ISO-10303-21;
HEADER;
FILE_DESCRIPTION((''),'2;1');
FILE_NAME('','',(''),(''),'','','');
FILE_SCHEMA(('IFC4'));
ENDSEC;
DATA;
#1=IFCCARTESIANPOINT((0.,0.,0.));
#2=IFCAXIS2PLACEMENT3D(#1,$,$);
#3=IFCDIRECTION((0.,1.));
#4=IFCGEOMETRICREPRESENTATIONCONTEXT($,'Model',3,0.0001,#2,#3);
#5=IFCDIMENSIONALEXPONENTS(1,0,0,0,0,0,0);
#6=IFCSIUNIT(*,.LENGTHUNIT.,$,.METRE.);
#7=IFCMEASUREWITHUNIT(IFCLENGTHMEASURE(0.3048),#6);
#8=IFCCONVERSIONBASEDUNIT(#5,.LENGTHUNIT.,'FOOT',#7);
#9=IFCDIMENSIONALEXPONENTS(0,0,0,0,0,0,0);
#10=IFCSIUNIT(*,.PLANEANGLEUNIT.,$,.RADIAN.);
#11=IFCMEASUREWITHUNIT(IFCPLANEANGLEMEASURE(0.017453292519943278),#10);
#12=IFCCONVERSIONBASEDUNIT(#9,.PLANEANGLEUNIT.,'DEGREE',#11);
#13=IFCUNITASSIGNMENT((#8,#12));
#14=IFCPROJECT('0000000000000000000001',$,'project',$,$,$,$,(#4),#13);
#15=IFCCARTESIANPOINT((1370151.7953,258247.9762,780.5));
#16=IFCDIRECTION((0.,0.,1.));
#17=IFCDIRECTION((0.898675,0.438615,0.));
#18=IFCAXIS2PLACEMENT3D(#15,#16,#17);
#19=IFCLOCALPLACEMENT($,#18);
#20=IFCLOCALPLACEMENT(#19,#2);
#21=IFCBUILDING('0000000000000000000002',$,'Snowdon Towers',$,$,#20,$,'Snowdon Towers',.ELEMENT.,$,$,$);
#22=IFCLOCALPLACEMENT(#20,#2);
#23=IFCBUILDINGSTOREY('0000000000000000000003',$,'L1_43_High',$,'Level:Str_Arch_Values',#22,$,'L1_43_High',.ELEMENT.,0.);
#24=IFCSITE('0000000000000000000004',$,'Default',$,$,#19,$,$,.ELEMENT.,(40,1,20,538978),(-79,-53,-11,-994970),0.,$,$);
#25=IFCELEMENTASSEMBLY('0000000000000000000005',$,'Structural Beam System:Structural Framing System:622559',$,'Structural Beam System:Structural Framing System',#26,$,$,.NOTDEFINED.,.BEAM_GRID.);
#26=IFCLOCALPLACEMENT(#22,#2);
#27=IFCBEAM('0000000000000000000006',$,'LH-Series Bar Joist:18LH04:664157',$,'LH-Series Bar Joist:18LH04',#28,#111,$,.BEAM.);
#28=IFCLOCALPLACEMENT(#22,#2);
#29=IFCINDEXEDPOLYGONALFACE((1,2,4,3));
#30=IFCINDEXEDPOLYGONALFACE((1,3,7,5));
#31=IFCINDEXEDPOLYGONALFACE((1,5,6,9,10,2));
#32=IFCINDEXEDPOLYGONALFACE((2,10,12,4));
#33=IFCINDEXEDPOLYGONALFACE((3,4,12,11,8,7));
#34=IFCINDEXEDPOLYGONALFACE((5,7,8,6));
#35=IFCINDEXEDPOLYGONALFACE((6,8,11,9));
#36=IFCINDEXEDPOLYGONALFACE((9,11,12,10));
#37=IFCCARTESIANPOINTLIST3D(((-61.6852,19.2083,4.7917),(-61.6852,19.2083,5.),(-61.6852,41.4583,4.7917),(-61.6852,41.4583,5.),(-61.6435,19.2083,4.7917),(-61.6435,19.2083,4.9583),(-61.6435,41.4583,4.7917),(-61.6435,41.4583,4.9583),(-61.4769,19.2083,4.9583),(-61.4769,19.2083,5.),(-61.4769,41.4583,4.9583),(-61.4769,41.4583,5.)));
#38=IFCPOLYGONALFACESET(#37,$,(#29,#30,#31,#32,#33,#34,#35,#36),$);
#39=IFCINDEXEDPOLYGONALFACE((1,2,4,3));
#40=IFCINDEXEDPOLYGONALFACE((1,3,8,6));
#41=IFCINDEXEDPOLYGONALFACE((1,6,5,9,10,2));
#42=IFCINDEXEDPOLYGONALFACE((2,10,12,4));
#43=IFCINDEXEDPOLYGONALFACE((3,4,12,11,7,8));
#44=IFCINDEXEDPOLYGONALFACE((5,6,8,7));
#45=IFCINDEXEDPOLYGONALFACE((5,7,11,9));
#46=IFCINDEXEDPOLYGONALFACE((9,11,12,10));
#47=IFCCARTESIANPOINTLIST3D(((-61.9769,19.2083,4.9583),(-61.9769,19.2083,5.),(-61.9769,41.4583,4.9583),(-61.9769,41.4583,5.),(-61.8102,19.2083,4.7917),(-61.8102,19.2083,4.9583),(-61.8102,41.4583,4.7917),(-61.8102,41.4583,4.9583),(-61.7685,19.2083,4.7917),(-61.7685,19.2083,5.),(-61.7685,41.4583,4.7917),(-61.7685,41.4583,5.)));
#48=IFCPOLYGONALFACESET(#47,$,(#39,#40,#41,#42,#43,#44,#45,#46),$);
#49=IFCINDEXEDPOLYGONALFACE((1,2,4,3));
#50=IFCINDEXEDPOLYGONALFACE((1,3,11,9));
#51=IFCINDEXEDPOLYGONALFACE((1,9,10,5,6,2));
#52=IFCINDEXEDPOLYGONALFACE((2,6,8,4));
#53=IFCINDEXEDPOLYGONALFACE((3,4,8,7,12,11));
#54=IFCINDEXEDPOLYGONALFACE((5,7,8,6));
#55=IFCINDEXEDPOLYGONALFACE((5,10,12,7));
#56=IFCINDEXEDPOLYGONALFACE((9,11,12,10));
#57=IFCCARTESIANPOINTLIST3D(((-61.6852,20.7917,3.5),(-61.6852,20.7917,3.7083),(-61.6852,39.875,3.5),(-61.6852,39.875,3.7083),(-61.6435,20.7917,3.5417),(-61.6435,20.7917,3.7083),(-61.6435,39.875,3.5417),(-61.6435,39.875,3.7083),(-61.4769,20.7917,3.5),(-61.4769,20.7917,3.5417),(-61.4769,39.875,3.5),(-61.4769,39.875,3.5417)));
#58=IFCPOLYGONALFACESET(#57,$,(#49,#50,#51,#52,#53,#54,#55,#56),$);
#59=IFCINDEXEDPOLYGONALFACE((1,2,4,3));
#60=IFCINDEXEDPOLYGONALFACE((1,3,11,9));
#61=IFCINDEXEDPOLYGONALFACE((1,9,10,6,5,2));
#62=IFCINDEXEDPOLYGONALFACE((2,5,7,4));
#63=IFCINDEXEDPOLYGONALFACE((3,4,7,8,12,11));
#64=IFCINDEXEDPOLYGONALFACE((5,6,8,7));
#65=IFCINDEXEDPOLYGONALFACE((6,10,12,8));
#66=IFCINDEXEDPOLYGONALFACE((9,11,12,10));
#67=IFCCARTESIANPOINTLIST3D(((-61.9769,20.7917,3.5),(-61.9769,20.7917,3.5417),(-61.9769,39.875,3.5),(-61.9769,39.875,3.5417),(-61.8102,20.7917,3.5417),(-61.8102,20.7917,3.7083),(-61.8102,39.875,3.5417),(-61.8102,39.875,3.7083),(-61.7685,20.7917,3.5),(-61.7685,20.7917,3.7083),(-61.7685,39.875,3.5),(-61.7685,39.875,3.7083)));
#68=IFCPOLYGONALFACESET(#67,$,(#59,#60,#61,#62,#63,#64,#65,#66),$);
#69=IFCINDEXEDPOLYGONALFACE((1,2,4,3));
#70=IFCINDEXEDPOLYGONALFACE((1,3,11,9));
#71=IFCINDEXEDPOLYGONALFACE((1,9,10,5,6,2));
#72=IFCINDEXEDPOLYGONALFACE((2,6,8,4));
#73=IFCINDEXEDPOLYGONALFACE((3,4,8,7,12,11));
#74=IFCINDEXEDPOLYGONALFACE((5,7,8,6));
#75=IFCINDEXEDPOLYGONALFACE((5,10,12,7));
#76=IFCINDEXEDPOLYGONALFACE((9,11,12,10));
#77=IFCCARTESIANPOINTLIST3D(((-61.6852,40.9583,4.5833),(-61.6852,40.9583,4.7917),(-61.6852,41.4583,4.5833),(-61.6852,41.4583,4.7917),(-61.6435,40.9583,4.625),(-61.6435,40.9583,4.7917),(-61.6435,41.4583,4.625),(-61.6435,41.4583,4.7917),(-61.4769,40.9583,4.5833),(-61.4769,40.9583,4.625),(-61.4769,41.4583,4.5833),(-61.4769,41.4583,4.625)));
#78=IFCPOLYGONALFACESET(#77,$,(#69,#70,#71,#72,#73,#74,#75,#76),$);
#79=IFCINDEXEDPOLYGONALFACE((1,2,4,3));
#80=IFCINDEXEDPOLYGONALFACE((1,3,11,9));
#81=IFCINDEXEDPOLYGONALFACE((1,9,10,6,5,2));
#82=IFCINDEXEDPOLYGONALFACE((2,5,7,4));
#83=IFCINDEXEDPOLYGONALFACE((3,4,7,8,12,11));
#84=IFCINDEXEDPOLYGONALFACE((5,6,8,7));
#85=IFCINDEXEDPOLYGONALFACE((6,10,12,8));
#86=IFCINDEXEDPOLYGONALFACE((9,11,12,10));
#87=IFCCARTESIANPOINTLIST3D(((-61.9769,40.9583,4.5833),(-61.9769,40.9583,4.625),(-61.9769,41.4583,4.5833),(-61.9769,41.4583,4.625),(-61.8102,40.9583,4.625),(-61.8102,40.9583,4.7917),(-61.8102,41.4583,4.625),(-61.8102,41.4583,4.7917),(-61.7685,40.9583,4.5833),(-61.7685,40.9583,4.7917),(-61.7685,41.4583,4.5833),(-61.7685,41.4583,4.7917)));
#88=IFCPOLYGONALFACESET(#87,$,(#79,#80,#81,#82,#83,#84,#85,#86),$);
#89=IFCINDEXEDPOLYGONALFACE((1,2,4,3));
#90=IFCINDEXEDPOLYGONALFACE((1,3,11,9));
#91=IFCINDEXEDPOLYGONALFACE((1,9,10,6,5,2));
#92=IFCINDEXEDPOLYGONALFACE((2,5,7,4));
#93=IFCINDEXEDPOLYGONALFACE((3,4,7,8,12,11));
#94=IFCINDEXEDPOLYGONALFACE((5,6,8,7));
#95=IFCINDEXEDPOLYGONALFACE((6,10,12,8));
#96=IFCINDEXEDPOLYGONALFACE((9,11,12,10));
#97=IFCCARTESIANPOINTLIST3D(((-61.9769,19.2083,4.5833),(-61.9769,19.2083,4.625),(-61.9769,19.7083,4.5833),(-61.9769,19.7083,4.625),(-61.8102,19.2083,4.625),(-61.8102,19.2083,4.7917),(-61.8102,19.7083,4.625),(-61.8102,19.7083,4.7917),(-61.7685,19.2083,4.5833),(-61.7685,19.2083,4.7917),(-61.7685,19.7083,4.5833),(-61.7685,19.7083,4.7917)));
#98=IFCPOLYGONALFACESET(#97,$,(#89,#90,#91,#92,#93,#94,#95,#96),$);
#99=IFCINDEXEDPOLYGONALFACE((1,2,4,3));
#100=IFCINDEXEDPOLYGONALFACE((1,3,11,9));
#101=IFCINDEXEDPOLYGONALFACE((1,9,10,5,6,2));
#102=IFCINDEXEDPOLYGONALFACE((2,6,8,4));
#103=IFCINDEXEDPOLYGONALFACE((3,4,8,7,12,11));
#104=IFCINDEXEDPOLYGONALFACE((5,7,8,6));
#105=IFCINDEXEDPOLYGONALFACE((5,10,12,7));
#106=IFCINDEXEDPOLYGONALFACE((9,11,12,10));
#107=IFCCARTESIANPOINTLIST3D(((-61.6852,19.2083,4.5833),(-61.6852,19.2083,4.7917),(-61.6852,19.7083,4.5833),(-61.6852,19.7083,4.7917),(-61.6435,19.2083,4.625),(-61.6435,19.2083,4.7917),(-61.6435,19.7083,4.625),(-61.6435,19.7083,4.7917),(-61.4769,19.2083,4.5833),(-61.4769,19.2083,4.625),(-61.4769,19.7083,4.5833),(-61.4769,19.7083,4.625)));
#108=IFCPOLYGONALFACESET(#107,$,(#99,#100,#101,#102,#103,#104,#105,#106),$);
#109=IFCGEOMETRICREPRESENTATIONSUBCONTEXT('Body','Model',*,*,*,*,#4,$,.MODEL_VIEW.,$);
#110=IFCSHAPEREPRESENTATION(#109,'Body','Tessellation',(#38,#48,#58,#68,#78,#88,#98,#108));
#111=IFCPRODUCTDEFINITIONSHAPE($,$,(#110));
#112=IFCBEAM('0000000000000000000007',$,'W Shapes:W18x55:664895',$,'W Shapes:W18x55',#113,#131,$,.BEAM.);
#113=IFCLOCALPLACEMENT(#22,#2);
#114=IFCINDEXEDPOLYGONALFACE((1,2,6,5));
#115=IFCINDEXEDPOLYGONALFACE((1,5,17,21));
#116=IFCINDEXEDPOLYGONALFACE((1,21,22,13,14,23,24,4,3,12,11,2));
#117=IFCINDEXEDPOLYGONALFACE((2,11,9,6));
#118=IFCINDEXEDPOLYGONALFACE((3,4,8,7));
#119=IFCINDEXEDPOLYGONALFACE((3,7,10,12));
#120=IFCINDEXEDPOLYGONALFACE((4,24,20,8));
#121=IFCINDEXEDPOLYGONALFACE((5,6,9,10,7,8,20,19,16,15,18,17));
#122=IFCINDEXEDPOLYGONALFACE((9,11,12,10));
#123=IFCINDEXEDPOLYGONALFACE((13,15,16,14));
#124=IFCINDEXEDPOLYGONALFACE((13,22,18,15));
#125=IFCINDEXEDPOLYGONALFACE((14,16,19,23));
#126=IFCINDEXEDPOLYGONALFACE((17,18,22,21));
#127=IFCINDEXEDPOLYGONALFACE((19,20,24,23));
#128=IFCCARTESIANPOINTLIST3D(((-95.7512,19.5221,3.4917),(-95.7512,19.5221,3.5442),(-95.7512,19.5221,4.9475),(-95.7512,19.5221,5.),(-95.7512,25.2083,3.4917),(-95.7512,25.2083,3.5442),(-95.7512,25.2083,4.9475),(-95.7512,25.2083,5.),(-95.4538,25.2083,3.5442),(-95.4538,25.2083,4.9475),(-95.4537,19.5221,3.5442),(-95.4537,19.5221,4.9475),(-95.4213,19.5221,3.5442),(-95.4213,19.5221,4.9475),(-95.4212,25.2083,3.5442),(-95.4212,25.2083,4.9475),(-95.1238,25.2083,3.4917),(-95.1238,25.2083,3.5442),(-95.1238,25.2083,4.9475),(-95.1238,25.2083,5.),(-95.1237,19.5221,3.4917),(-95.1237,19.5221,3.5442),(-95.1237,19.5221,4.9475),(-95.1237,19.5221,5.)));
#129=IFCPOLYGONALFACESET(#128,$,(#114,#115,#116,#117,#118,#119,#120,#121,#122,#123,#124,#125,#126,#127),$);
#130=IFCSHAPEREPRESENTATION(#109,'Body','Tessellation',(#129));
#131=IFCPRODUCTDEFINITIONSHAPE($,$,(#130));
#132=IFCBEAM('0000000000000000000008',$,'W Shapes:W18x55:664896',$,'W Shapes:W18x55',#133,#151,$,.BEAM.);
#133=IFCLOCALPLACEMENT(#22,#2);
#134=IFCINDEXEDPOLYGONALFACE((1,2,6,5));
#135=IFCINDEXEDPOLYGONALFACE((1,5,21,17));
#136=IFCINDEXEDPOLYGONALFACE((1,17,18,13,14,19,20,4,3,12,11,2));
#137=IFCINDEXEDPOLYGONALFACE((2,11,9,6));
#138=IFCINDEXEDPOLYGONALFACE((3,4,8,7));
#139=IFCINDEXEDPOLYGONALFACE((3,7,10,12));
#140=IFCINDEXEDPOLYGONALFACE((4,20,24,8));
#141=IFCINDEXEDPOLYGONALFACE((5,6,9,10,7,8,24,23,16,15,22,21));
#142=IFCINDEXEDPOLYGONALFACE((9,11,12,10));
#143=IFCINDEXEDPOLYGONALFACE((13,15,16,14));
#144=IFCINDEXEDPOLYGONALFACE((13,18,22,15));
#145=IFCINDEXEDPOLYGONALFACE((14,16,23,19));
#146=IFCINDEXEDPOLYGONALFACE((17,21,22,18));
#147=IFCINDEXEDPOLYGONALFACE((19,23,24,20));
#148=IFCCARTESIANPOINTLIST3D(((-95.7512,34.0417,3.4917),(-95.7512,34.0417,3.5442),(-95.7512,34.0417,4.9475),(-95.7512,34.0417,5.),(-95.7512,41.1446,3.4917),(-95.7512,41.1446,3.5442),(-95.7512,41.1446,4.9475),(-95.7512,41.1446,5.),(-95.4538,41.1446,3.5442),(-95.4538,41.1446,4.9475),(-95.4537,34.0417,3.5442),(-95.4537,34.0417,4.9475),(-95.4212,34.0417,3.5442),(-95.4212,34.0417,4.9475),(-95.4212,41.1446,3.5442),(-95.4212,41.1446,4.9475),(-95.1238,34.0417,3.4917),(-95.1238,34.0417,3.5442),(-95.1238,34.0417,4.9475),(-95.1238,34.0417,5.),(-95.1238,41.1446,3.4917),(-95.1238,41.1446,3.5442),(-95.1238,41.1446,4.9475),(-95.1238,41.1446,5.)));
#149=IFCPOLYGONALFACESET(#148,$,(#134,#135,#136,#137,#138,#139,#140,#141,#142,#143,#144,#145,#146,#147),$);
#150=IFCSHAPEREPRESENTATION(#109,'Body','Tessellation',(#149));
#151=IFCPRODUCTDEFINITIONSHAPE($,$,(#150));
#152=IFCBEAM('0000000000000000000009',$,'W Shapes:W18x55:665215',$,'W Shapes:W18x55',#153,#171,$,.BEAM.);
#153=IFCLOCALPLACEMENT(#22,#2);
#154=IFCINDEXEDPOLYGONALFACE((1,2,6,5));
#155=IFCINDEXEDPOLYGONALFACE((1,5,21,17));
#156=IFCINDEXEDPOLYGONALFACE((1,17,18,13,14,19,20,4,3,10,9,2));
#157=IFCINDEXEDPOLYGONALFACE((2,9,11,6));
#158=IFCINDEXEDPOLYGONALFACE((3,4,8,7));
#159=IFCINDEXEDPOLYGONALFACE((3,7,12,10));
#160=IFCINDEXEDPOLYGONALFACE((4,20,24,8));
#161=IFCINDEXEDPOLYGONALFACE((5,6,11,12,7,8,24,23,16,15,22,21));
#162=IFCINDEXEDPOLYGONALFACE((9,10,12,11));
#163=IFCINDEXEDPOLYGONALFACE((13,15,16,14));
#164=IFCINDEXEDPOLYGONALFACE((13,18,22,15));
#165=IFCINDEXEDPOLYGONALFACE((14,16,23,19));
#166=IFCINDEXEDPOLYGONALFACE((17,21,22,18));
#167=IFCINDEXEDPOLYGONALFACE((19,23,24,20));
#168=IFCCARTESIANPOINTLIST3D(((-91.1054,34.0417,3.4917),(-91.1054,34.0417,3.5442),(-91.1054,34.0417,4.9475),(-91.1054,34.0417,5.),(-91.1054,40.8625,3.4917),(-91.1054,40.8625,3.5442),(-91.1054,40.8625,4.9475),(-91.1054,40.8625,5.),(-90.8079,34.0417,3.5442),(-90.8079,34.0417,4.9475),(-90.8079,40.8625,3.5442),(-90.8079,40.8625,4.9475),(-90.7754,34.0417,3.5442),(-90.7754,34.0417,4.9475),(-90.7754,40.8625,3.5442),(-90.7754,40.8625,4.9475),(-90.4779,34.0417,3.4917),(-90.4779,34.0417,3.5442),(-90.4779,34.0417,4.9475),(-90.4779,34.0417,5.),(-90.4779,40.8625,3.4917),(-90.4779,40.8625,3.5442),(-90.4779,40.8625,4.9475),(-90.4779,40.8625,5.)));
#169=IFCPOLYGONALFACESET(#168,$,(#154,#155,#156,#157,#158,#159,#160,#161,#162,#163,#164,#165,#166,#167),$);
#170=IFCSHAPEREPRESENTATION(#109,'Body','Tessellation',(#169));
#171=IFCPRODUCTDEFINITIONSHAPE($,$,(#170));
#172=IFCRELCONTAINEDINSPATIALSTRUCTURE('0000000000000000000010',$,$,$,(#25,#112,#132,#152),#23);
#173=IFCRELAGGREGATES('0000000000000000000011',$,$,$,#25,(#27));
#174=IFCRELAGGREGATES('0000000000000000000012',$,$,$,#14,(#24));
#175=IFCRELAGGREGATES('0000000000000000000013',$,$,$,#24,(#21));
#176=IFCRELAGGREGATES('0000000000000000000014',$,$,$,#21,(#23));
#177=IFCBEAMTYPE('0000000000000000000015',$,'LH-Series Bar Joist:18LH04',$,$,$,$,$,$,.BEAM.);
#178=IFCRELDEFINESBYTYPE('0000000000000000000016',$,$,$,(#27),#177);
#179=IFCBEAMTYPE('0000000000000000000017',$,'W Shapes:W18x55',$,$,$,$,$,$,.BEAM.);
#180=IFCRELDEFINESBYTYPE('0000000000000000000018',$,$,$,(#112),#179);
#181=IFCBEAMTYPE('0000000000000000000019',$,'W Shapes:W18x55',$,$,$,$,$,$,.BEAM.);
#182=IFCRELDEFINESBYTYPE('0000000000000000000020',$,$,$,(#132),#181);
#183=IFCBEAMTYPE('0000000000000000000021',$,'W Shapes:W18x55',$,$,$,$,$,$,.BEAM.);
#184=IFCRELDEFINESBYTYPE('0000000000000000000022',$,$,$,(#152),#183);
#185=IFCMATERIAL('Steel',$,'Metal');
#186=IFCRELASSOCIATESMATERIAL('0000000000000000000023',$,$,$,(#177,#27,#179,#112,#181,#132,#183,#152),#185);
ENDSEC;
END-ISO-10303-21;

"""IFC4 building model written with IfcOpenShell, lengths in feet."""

from ifc_helpers import new_model, entity, si_unit, converted_unit, direction, frame, origin, place, context, subcontext, project, spatial, indexed_curve, outline, extrude, source, transform, mapped, material, type_object, type_shapes, element, aggregate, save


model = new_model("IFC4")

# Units and contexts
model_context = context("Model", 3, precision=0.0001, world=origin(), true_north=direction((0.0, 1.0)))
body_context = subcontext(model_context, "Body", "Model", "MODEL_VIEW")
ifc_project = project(units=[converted_unit("LENGTHUNIT", "FOOT", entity("IfcLengthMeasure", 0.3048), si_unit("LENGTHUNIT", "METRE"), dimensions=[1, 0, 0, 0, 0, 0, 0]), converted_unit("PLANEANGLEUNIT", "DEGREE", entity("IfcPlaneAngleMeasure", 0.017453292519943278), si_unit("PLANEANGLEUNIT", "RADIAN"), dimensions=[0, 0, 0, 0, 0, 0, 0])], contexts=[model_context])

# Site, building, storey
site_placement = place(None, frame((1370151.7953, 258247.9762, 780.5), z_axis=(0.0, 0.0, 1.0), x_axis=(0.898675, 0.438615, 0.0)))
site = spatial("IfcSite", under=ifc_project, at=site_placement, Name="Default", CompositionType="ELEMENT", RefLatitude=(40, 1, 20, 538978), RefLongitude=(-79, -53, -11, -994970), RefElevation=0.0)
building_placement = place(site_placement, origin())
building = spatial("IfcBuilding", under=site, at=building_placement, Name="Snowdon Towers", LongName="Snowdon Towers", CompositionType="ELEMENT")
storey_placement = place(building_placement, origin())
storey = spatial("IfcBuildingStorey", under=building, at=storey_placement, Name="L1_43_High", ObjectType="Level:Str_Arch_Values", LongName="L1_43_High", CompositionType="ELEMENT", Elevation=0.0)

# Shared definitions
ifc_material_1 = material(Name="Steel", Category="Metal")

# Element assembly, beam
assembly_placement = place(storey_placement, origin())
assembly = element("IfcElementAssembly", 1, at=assembly_placement, inside=storey, Name="Structural Beam System:Structural Framing System:622559", ObjectType="Structural Beam System:Structural Framing System", AssemblyPlace="NOTDEFINED", PredefinedType="BEAM_GRID")
beam_type_1 = type_object("IfcBeamType", Name="LH-Series Bar Joist:18LH04", PredefinedType="BEAM", material=ifc_material_1)
shared_shape_1 = source(origin(), body_context, "Body", "SweptSolid", [
    extrude(outline(indexed_curve([(-0.0833, -0.0833), (0.125, -0.0833), (0.125, -0.0417), (-0.0417, -0.0417), (-0.0417, 0.125), (-0.0833, 0.125), (-0.0833, -0.0833)], self_intersect=False)), frame((-11.125, -0.125, 0.6667), z_axis=(1.0, 0.0, 0.0), x_axis=(0.0, -1.0, 0.0)), (0.0, 0.0, 1.0), 22.25),
    extrude(outline(indexed_curve([(-0.0833, -0.0833), (0.125, -0.0833), (0.125, -0.0417), (-0.0417, -0.0417), (-0.0417, 0.125), (-0.0833, 0.125), (-0.0833, -0.0833)], self_intersect=False)), frame((-11.125, 0.125, 0.6667), z_axis=(1.0, 0.0, 0.0), x_axis=(0.0, 0.0, -1.0)), (0.0, 0.0, 1.0), 22.25),
    extrude(outline(indexed_curve([(-0.0833, -0.0833), (0.125, -0.0833), (0.125, -0.0417), (-0.0417, -0.0417), (-0.0417, 0.125), (-0.0833, 0.125), (-0.0833, -0.0833)], self_intersect=False)), frame((-9.5417, -0.125, -0.6667), z_axis=(1.0, 0.0, 0.0), x_axis=(0.0, 0.0, 1.0)), (0.0, 0.0, 1.0), 19.0833),
    extrude(outline(indexed_curve([(-0.0833, -0.0833), (0.125, -0.0833), (0.125, -0.0417), (-0.0417, -0.0417), (-0.0417, 0.125), (-0.0833, 0.125), (-0.0833, -0.0833)], self_intersect=False)), frame((-9.5417, 0.125, -0.6667), z_axis=(1.0, 0.0, 0.0), x_axis=(0.0, 1.0, 0.0)), (0.0, 0.0, 1.0), 19.0833),
    extrude(outline(indexed_curve([(-0.0833, -0.0833), (0.125, -0.0833), (0.125, -0.0417), (-0.0417, -0.0417), (-0.0417, 0.125), (-0.0833, 0.125), (-0.0833, -0.0833)], self_intersect=False)), frame((10.625, -0.125, 0.4167), z_axis=(1.0, 0.0, 0.0), x_axis=(0.0, 0.0, 1.0)), (0.0, 0.0, 1.0), 0.5),
    extrude(outline(indexed_curve([(-0.0833, -0.0833), (0.125, -0.0833), (0.125, -0.0417), (-0.0417, -0.0417), (-0.0417, 0.125), (-0.0833, 0.125), (-0.0833, -0.0833)], self_intersect=False)), frame((10.625, 0.125, 0.4167), z_axis=(1.0, 0.0, 0.0), x_axis=(0.0, 1.0, 0.0)), (0.0, 0.0, 1.0), 0.5),
    extrude(outline(indexed_curve([(-0.0833, -0.125), (-0.0417, -0.125), (-0.0417, 0.0417), (0.125, 0.0417), (0.125, 0.0833), (-0.0833, 0.0833), (-0.0833, -0.125)], self_intersect=False)), frame((-11.125, 0.125, 0.4167), z_axis=(1.0, 0.0, 0.0), x_axis=(0.0, 0.0, 1.0)), (0.0, 0.0, 1.0), 0.5),
    extrude(outline(indexed_curve([(-0.0833, -0.0833), (0.125, -0.0833), (0.125, -0.0417), (-0.0417, -0.0417), (-0.0417, 0.125), (-0.0833, 0.125), (-0.0833, -0.0833)], self_intersect=False)), frame((-11.125, -0.125, 0.4167), z_axis=(1.0, 0.0, 0.0), x_axis=(0.0, 0.0, 1.0)), (0.0, 0.0, 1.0), 0.5),
])
type_shapes(beam_type_1, [shared_shape_1])
beam_1_placement = place(assembly_placement, frame((-61.7269, 30.3333, 4.25), z_axis=(0.0, 0.0, 1.0), x_axis=(0.0, 1.0, 0.0)))
beam_1 = element("IfcBeam", 2, at=beam_1_placement, type_object=beam_type_1, material=ifc_material_1, Name="LH-Series Bar Joist:18LH04:664157", ObjectType="LH-Series Bar Joist:18LH04", PredefinedType="BEAM", context=body_context, shape_type="MappedRepresentation", body=[
    mapped(shared_shape_1, transform((0.0, 0.0, 0.0), scale=1.0)),
])
aggregate(assembly, [beam_1])

# Beams
beam_type_2 = type_object("IfcBeamType", Name="W Shapes:W18x55", PredefinedType="BEAM", material=ifc_material_1)
shared_shape_2 = source(origin(), body_context, "Body", "SweptSolid", [
    extrude(outline(indexed_curve([(-0.3138, -0.7017), (-0.3138, -0.7542), (0.3138, -0.7542), (0.3138, -0.7017), (0.0162, -0.7017), (0.0162, 0.7017), (0.3138, 0.7017), (0.3138, 0.7542), (-0.3137, 0.7542), (-0.3137, 0.7017), (-0.0163, 0.7017), (-0.0163, -0.7017), (-0.3138, -0.7017)], self_intersect=False)), frame((-2.8946, 0.0, 0.0), z_axis=(-1.0, 0.0, 0.0), x_axis=(0.0, -1.0, 0.0)), (0.0, 0.0, -1.0), 5.6862),
])
type_shapes(beam_type_2, [shared_shape_2])
beam_2_placement = place(storey_placement, frame((-95.4375, 22.4167, 4.2458), z_axis=(0.0, 0.0, 1.0), x_axis=(0.0, 1.0, 0.0)))
element("IfcBeam", 3, at=beam_2_placement, inside=storey, type_object=beam_type_2, material=ifc_material_1, Name="W Shapes:W18x55:664895", ObjectType="W Shapes:W18x55", PredefinedType="BEAM", context=body_context, shape_type="MappedRepresentation", body=[
    mapped(shared_shape_2, transform((0.0, 0.0, 0.0), scale=1.0)),
])
beam_type_3 = type_object("IfcBeamType", Name="W Shapes:W18x55", PredefinedType="BEAM", material=ifc_material_1)
shared_shape_3 = source(origin(), body_context, "Body", "SweptSolid", [
    extrude(outline(indexed_curve([(-0.3138, -0.7017), (-0.3138, -0.7542), (0.3138, -0.7542), (0.3138, -0.7017), (0.0162, -0.7017), (0.0162, 0.7017), (0.3138, 0.7017), (0.3138, 0.7542), (-0.3137, 0.7542), (-0.3137, 0.7017), (-0.0163, 0.7017), (-0.0163, -0.7017), (-0.3138, -0.7017)], self_intersect=False)), frame((-3.4779, 0.0, 0.0), z_axis=(-1.0, 0.0, 0.0), x_axis=(0.0, -1.0, 0.0)), (0.0, 0.0, -1.0), 7.1029),
])
type_shapes(beam_type_3, [shared_shape_3])
beam_3_placement = place(storey_placement, frame((-95.4375, 37.6667, 4.2458), z_axis=(0.0, 0.0, 1.0), x_axis=(0.0, -1.0, 0.0)))
element("IfcBeam", 4, at=beam_3_placement, inside=storey, type_object=beam_type_3, material=ifc_material_1, Name="W Shapes:W18x55:664896", ObjectType="W Shapes:W18x55", PredefinedType="BEAM", context=body_context, shape_type="MappedRepresentation", body=[
    mapped(shared_shape_3, transform((0.0, 0.0, 0.0), scale=1.0)),
])
beam_type_4 = type_object("IfcBeamType", Name="W Shapes:W18x55", PredefinedType="BEAM", material=ifc_material_1)
shared_shape_4 = source(origin(), body_context, "Body", "SweptSolid", [
    extrude(outline(indexed_curve([(-0.3138, -0.7017), (-0.3138, -0.7542), (0.3138, -0.7542), (0.3138, -0.7017), (0.0162, -0.7017), (0.0162, 0.7017), (0.3138, 0.7017), (0.3138, 0.7542), (-0.3137, 0.7542), (-0.3137, 0.7017), (-0.0163, 0.7017), (-0.0163, -0.7017), (-0.3138, -0.7017)], self_intersect=False)), frame((-2.9042, 0.0, 0.0), z_axis=(-1.0, 0.0, 0.0), x_axis=(0.0, -1.0, 0.0)), (0.0, 0.0, -1.0), 6.8208),
])
type_shapes(beam_type_4, [shared_shape_4])
beam_4_placement = place(storey_placement, frame((-90.7917, 37.9583, 4.2458), z_axis=(0.0, 0.0, 1.0), x_axis=(0.0, -1.0, 0.0)))
element("IfcBeam", 5, at=beam_4_placement, inside=storey, type_object=beam_type_4, material=ifc_material_1, Name="W Shapes:W18x55:665215", ObjectType="W Shapes:W18x55", PredefinedType="BEAM", context=body_context, shape_type="MappedRepresentation", body=[
    mapped(shared_shape_4, transform((0.0, 0.0, 0.0), scale=1.0)),
])

save(model, "model.ifc")
